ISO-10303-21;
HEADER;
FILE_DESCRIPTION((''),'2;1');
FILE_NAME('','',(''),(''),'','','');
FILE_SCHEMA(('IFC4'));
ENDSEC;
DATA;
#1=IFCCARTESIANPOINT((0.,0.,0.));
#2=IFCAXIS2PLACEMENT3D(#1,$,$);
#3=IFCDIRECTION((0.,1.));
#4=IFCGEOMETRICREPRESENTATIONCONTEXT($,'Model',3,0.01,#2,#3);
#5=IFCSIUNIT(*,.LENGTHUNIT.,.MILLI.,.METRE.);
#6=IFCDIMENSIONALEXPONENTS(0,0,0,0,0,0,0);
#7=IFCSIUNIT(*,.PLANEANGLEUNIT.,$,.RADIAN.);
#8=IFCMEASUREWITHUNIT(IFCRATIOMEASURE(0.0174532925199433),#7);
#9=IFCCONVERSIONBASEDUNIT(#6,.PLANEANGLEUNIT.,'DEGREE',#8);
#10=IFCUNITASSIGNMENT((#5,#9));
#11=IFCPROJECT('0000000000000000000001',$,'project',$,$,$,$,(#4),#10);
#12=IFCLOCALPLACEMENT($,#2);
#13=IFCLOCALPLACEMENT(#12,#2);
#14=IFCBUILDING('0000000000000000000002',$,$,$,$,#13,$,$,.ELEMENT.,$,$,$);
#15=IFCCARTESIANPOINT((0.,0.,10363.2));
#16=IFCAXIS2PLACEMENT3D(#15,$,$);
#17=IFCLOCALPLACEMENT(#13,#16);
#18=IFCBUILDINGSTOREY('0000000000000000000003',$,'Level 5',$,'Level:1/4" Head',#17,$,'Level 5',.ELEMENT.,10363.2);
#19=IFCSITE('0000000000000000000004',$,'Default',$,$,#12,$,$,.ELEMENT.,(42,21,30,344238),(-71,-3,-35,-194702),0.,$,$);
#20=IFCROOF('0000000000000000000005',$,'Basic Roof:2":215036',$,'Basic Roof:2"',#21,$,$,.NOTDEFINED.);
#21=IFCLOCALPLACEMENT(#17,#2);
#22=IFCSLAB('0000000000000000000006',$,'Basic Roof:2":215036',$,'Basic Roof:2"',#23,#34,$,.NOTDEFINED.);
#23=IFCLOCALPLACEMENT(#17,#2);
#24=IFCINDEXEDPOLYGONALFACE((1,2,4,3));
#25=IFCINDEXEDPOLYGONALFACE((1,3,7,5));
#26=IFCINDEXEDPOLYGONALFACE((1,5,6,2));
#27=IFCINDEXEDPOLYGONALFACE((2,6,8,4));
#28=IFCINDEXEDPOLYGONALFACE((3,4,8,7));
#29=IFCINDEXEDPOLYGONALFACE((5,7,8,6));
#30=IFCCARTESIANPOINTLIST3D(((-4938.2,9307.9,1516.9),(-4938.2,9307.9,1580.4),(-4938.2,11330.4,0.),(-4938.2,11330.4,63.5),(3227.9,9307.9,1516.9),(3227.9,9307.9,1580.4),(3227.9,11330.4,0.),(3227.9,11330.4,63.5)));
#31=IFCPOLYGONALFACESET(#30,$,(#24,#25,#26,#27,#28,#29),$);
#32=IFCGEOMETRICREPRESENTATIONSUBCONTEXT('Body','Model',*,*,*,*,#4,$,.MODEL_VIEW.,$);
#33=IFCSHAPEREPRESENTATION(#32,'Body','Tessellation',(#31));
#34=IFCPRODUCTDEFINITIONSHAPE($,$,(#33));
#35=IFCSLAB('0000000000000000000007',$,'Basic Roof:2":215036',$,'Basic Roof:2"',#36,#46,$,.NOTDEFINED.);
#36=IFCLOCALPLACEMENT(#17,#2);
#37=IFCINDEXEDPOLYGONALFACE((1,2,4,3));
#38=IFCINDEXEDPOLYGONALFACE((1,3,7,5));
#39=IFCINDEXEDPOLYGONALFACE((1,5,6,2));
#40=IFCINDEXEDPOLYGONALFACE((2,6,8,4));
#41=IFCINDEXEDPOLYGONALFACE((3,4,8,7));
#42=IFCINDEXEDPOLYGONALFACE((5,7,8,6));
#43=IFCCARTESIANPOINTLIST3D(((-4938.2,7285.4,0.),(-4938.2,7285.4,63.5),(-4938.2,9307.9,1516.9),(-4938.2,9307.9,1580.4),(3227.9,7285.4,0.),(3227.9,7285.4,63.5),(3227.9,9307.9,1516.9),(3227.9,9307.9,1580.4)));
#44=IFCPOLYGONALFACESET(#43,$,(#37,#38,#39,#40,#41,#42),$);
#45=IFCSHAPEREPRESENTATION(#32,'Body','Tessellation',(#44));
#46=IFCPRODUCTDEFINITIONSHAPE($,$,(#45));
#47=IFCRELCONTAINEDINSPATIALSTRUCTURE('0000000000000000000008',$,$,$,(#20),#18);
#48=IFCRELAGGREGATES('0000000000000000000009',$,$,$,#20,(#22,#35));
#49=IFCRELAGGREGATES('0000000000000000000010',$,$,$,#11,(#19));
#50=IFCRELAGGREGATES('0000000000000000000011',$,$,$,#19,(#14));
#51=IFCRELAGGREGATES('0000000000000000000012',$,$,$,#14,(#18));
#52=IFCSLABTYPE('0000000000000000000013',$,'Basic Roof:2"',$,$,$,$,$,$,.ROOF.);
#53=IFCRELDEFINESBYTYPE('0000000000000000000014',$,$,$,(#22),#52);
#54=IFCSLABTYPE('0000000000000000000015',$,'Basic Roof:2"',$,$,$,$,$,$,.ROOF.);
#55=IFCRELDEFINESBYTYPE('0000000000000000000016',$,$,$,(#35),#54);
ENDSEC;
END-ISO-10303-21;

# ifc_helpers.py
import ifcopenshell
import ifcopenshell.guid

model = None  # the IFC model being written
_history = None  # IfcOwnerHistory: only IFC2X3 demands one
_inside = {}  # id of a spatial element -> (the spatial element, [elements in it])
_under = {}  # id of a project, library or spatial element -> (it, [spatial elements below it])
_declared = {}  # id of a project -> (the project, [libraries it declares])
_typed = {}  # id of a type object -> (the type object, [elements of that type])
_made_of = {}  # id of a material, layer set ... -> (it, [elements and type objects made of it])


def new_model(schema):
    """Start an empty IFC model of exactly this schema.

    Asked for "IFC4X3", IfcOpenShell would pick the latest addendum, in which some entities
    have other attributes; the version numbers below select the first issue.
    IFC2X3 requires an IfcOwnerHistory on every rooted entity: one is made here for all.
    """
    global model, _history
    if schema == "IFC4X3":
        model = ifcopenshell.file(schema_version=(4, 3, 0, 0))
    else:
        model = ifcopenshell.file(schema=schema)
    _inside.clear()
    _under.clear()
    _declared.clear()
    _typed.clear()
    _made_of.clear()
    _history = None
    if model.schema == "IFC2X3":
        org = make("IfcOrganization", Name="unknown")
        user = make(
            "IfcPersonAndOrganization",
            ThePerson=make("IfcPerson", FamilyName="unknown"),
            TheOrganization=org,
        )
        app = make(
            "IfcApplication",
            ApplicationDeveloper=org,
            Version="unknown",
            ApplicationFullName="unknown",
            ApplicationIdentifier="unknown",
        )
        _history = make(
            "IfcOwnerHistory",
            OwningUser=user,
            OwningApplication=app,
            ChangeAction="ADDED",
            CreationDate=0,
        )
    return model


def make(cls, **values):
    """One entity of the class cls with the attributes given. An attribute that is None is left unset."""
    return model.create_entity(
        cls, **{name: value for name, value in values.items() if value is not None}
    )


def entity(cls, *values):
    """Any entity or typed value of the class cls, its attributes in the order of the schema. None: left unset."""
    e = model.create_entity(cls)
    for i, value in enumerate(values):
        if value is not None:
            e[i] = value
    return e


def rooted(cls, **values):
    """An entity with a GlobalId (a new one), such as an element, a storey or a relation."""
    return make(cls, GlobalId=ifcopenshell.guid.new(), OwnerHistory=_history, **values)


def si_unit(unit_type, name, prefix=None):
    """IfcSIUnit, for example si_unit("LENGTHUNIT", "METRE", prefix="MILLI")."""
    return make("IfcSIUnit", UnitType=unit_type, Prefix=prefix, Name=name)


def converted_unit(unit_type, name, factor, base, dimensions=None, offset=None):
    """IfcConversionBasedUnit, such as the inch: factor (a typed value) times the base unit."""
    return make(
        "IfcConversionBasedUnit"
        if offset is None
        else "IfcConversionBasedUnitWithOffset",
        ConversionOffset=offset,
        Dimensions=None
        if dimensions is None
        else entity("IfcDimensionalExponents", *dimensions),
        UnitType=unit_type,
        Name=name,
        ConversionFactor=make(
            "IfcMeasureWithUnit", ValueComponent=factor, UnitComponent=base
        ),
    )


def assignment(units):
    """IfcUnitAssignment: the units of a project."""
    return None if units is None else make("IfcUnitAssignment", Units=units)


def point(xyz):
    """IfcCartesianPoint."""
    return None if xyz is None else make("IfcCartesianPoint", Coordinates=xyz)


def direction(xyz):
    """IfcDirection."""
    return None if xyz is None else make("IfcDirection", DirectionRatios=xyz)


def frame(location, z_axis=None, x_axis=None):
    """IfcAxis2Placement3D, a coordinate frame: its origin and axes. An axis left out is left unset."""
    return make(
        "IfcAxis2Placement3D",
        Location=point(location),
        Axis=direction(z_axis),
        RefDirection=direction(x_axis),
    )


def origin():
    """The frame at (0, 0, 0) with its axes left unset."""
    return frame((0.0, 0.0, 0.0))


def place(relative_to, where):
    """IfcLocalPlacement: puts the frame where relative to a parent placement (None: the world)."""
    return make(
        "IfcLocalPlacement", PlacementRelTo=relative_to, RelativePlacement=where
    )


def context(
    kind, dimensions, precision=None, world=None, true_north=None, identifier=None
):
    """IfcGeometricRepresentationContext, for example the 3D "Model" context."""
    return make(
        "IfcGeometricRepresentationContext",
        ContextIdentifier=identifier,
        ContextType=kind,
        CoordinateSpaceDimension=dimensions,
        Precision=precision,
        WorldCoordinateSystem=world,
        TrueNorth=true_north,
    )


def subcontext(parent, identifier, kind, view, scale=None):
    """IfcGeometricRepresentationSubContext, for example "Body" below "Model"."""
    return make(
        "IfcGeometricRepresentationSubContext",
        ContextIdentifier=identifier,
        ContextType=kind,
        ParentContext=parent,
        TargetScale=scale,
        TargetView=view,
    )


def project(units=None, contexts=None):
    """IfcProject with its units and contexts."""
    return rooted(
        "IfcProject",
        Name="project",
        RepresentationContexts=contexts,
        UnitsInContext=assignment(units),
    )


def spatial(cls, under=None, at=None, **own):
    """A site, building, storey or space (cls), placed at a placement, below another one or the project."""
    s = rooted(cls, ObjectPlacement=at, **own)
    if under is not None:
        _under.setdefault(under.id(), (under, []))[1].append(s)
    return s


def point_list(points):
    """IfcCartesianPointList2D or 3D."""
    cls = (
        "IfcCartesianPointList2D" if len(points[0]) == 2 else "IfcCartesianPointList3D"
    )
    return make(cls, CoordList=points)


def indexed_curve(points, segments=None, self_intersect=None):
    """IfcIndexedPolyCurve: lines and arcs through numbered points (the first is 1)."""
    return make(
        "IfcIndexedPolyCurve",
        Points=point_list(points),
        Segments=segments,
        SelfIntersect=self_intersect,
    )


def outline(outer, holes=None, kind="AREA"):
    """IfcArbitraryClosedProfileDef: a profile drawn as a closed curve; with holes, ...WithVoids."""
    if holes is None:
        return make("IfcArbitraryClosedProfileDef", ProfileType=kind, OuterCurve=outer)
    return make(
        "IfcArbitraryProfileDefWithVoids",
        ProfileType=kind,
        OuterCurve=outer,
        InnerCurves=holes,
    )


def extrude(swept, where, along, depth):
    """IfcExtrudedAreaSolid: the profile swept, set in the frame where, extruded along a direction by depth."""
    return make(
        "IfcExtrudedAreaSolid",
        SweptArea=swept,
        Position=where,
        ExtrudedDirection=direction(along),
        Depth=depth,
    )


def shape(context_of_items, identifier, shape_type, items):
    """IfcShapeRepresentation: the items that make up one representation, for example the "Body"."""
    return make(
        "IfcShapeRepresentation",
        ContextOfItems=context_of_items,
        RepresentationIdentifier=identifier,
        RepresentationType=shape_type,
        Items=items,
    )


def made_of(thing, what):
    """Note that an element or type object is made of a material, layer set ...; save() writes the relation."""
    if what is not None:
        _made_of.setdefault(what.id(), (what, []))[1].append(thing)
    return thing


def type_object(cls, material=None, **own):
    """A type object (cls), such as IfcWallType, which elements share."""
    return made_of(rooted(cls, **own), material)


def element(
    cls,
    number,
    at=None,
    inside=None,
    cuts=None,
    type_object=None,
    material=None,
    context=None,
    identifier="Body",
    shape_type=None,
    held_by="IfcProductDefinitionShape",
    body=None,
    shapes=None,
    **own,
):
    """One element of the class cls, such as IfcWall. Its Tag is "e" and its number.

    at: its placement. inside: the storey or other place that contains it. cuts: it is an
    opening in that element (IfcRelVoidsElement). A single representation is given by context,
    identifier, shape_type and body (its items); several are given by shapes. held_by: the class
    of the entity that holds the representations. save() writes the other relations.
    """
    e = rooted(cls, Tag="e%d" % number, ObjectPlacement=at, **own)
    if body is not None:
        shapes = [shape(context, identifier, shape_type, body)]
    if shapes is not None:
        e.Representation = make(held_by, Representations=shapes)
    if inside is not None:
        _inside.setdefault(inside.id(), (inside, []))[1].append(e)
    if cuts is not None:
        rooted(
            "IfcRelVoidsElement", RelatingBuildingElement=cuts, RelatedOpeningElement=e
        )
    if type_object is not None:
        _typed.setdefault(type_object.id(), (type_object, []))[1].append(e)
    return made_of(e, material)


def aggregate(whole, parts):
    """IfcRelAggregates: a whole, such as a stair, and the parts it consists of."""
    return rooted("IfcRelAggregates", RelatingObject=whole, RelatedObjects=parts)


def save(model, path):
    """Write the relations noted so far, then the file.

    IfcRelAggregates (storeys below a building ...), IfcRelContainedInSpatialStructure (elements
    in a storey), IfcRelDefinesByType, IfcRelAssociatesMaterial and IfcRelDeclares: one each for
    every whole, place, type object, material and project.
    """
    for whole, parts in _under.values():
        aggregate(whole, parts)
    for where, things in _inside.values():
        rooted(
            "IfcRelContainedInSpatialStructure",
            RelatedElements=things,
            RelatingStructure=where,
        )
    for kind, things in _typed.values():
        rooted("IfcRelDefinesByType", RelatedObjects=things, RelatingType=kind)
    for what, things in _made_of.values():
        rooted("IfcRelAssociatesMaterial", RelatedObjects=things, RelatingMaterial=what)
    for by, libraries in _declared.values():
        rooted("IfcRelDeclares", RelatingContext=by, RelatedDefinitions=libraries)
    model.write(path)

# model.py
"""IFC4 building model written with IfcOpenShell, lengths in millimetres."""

from ifc_helpers import new_model, entity, si_unit, converted_unit, direction, frame, origin, place, context, subcontext, project, spatial, indexed_curve, outline, extrude, type_object, element, aggregate, save


model = new_model("IFC4")

# Units and contexts
model_context = context("Model", 3, precision=0.01, world=origin(), true_north=direction((0.0, 1.0)))
body_context = subcontext(model_context, "Body", "Model", "MODEL_VIEW")
ifc_project = project(units=[si_unit("LENGTHUNIT", "METRE", prefix="MILLI"), converted_unit("PLANEANGLEUNIT", "DEGREE", entity("IfcRatioMeasure", 0.0174532925199433), si_unit("PLANEANGLEUNIT", "RADIAN"), dimensions=[0, 0, 0, 0, 0, 0, 0])], contexts=[model_context])

# Site, building, storey
site_placement = place(None, origin())
site = spatial("IfcSite", under=ifc_project, at=site_placement, Name="Default", CompositionType="ELEMENT", RefLatitude=(42, 21, 30, 344238), RefLongitude=(-71, -3, -35, -194702), RefElevation=0.0)
building_placement = place(site_placement, origin())
building = spatial("IfcBuilding", under=site, at=building_placement, CompositionType="ELEMENT")
storey_placement = place(building_placement, frame((0.0, 0.0, 10363.2)))
storey = spatial("IfcBuildingStorey", under=building, at=storey_placement, Name="Level 5", ObjectType="Level:1/4\" Head", LongName="Level 5", CompositionType="ELEMENT", Elevation=10363.2)

# Roof, slabs
roof_placement = place(storey_placement, frame((-4938.2, 7285.4, 0.0)))
roof = element("IfcRoof", 1, at=roof_placement, inside=storey, Name="Basic Roof:2\":215036", ObjectType="Basic Roof:2\"", PredefinedType="NOTDEFINED")
slab_type_1 = type_object("IfcSlabType", Name="Basic Roof:2\"", PredefinedType="ROOF")
slab_1_placement = place(roof_placement, origin())
slab_1 = element("IfcSlab", 2, at=slab_1_placement, type_object=slab_type_1, Name="Basic Roof:2\":215036", ObjectType="Basic Roof:2\"", PredefinedType="NOTDEFINED", context=body_context, shape_type="SweptSolid", body=[
    extrude(outline(indexed_curve([(-4083.0, -1264.0), (4083.0, -1264.0), (4083.0, 1264.0), (-4083.0, 1264.0), (-4083.0, -1264.0)], self_intersect=False)), frame((4083.0, 3033.7, 758.4), z_axis=(0.0, 0.6, 0.8), x_axis=(1.0, 0.0, 0.0)), (0.0, -0.6, 0.8), 63.5),
])
slab_type_2 = type_object("IfcSlabType", Name="Basic Roof:2\"", PredefinedType="ROOF")
slab_2_placement = place(roof_placement, origin())
slab_2 = element("IfcSlab", 3, at=slab_2_placement, type_object=slab_type_2, Name="Basic Roof:2\":215036", ObjectType="Basic Roof:2\"", PredefinedType="NOTDEFINED", context=body_context, shape_type="SweptSolid", body=[
    extrude(outline(indexed_curve([(4083.0, -1264.0), (4083.0, 1264.0), (-4083.0, 1264.0), (-4083.0, -1264.0), (4083.0, -1264.0)], self_intersect=False)), frame((4083.0, 1011.2, 758.4), z_axis=(0.0, -0.6, 0.8), x_axis=(1.0, 0.0, 0.0)), (0.0, 0.6, 0.8), 63.5),
])
aggregate(roof, [slab_1, slab_2])

save(model, "model.ifc")
